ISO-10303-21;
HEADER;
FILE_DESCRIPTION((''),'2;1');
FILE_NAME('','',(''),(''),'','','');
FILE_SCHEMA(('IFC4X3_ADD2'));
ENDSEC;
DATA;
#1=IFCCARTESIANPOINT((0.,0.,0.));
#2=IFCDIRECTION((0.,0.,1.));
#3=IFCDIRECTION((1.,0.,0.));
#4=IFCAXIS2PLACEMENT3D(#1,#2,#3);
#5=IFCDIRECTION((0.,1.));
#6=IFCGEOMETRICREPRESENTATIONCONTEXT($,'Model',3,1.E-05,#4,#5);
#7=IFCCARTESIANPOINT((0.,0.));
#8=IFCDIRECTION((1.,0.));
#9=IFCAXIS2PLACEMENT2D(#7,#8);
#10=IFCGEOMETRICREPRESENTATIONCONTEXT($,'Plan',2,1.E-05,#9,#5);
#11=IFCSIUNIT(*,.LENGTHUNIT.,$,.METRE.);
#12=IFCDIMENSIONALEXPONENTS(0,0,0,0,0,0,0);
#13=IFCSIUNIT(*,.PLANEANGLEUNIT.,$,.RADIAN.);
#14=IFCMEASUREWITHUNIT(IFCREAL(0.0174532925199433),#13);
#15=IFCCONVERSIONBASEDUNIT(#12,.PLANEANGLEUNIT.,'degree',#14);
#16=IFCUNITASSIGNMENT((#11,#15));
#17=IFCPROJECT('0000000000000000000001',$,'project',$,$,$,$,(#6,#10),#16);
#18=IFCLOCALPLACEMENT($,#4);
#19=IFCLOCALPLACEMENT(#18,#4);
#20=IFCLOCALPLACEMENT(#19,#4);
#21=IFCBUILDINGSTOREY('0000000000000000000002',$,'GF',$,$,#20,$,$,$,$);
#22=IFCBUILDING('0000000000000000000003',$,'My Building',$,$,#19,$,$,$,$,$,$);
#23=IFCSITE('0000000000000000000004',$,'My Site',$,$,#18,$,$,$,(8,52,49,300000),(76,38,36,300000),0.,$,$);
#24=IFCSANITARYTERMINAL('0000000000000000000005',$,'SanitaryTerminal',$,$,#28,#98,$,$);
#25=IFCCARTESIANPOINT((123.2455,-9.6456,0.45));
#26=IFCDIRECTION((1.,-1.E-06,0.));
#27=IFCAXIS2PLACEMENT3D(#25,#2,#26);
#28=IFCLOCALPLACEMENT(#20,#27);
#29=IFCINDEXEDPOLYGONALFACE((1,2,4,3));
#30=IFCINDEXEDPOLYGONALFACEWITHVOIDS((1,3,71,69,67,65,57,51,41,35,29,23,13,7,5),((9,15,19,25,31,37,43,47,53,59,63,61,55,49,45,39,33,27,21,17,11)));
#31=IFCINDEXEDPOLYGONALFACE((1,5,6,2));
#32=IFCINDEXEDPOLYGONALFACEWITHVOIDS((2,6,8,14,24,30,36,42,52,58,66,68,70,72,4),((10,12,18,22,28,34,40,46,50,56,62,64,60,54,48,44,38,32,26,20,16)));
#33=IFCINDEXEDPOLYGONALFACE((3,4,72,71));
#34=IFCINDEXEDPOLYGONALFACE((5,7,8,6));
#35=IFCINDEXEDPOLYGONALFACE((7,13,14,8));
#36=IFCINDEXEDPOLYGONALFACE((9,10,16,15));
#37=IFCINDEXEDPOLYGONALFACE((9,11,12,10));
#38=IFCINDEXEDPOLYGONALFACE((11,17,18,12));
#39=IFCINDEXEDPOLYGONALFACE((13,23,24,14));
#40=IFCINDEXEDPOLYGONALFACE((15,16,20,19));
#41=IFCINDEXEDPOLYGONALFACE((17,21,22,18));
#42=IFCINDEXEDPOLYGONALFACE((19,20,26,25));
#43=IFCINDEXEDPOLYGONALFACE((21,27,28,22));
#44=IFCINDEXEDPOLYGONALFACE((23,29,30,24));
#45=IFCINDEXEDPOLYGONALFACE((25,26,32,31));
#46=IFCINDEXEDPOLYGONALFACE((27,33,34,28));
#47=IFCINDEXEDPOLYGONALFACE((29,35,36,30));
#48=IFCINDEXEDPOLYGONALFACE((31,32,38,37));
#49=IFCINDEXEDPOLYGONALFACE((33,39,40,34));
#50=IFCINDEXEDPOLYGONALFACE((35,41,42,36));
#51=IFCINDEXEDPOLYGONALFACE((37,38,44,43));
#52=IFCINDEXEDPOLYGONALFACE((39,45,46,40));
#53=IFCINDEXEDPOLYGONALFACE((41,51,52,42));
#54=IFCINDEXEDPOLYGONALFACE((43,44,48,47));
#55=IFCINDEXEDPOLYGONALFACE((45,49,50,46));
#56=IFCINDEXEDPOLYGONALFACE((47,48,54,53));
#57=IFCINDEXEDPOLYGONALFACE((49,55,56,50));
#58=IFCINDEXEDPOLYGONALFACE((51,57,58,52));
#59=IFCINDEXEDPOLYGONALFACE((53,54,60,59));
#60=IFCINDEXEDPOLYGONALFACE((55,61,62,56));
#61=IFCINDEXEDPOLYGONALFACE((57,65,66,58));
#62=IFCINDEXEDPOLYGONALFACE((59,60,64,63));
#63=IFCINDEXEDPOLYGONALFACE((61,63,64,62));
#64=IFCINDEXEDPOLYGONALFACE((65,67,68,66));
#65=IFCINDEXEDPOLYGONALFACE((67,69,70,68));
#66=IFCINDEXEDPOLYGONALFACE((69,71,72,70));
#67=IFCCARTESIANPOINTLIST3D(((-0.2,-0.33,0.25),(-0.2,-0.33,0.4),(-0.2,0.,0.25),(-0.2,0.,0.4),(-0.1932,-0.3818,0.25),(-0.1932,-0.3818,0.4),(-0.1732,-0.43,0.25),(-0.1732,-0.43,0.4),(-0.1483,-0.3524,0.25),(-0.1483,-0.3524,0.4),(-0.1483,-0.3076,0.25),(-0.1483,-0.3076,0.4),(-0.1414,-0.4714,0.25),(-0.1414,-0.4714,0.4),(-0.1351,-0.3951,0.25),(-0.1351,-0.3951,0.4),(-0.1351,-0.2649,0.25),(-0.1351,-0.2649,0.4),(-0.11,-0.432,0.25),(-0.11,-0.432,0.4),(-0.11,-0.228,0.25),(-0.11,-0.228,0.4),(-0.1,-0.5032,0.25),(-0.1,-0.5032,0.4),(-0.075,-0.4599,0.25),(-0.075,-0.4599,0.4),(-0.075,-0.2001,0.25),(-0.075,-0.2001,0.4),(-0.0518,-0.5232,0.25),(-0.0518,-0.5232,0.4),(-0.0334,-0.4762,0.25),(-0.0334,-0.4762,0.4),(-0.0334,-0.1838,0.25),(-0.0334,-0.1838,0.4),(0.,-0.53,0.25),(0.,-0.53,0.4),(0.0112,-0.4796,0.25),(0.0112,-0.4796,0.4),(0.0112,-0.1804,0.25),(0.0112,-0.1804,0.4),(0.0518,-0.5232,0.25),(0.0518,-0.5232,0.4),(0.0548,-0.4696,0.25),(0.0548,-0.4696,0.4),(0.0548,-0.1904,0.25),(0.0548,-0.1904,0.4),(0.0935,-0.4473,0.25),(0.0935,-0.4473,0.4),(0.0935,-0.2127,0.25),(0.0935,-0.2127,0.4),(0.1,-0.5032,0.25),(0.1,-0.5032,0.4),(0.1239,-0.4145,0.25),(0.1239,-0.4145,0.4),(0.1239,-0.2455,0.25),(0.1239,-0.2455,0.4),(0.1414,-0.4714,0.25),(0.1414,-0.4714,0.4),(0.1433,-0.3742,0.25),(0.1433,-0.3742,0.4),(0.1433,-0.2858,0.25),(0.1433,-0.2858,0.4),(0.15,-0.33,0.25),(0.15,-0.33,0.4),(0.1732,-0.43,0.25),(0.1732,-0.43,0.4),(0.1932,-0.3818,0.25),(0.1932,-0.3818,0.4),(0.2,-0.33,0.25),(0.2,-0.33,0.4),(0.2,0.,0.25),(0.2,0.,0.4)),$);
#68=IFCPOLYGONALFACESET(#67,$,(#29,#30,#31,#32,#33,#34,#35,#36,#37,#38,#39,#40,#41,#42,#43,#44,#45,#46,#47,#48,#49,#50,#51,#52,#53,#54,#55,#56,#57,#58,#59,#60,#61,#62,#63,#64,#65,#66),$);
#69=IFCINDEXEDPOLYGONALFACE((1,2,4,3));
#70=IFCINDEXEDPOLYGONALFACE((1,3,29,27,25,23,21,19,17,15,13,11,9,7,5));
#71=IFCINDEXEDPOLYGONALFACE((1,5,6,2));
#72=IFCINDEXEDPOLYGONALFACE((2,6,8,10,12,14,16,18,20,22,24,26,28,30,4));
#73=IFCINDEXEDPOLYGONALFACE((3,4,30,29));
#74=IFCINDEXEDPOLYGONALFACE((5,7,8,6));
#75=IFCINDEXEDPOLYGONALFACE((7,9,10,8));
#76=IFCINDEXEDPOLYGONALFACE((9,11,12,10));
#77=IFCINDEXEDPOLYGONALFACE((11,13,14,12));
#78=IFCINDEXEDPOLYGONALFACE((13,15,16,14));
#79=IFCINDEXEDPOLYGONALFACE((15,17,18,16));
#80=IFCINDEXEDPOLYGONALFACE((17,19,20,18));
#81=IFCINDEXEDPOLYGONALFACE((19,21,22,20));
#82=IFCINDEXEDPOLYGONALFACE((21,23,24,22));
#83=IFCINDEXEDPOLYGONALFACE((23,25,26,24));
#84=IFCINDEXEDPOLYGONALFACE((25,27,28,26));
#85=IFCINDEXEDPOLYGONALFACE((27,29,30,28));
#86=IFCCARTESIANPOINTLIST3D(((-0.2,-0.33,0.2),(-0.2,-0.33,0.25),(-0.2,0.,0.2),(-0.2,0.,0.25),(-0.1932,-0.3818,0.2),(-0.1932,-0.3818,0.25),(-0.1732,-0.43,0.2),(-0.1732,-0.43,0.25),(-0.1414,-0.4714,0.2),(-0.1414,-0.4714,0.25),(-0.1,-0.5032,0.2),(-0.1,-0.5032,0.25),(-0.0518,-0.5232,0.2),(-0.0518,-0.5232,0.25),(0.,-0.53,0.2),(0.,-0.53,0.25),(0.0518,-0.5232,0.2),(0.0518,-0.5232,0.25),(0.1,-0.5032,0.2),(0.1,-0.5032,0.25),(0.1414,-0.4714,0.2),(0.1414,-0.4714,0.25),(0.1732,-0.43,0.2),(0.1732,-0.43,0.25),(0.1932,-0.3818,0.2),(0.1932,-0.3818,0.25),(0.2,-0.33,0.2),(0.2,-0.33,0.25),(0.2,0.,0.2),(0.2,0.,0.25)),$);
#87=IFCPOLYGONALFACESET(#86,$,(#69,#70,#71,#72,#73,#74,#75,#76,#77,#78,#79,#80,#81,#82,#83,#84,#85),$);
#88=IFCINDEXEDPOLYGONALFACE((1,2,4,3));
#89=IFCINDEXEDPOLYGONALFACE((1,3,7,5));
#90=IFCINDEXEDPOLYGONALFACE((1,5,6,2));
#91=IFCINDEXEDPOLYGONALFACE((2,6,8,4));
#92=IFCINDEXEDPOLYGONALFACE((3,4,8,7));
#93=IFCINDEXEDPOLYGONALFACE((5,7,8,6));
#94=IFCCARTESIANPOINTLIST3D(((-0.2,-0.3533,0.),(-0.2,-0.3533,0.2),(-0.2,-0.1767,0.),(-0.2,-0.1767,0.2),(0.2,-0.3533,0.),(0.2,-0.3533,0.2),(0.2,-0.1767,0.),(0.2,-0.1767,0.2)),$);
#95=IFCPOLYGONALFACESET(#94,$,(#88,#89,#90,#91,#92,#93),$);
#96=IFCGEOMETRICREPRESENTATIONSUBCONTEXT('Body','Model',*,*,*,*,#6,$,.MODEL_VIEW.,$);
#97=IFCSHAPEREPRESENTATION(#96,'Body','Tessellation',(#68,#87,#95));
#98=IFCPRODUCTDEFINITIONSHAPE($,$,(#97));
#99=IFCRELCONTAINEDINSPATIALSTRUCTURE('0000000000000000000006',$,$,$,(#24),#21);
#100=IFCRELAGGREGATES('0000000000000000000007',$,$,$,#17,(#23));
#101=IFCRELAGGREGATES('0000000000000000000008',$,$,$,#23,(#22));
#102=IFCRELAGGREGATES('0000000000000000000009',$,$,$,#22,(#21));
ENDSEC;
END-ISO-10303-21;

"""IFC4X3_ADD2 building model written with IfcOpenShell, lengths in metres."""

from ifc_helpers import new_model, entity, si_unit, converted_unit, direction, frame, frame_2d, origin_with_axes, origin_2d_with_axis, place, context, subcontext, project, spatial, line, arc, indexed_curve, circle_curve, outline, extrude, shape, element, save


model = new_model("IFC4X3_ADD2")

# Units and contexts
model_context = context("Model", 3, precision=1e-05, world=origin_with_axes(), true_north=direction((0.0, 1.0)))
plan_context = context("Plan", 2, precision=1e-05, world=origin_2d_with_axis(), true_north=direction((0.0, 1.0)))
body_context_1 = subcontext(model_context, "Body", "Model", "MODEL_VIEW")
body_context_2 = subcontext(plan_context, "Body", "Plan", "PLAN_VIEW")
ifc_project = project(units=[si_unit("LENGTHUNIT", "METRE"), converted_unit("PLANEANGLEUNIT", "degree", entity("IfcReal", 0.0174532925199433), si_unit("PLANEANGLEUNIT", "RADIAN"), dimensions=[0, 0, 0, 0, 0, 0, 0])], contexts=[model_context, plan_context])

# Site, building, storey
site_placement = place(None, origin_with_axes())
site = spatial("IfcSite", under=ifc_project, at=site_placement, Name="My Site", RefLatitude=(8, 52, 49, 300000), RefLongitude=(76, 38, 36, 300000), RefElevation=0.0)
building_placement = place(site_placement, origin_with_axes())
building = spatial("IfcBuilding", under=site, at=building_placement, Name="My Building")
storey_placement = place(building_placement, origin_with_axes())
storey = spatial("IfcBuildingStorey", under=building, at=storey_placement, Name="GF")

# Sanitary terminal
sanitary_terminal_1_placement = place(storey_placement, frame((123.2455, -9.6456, 0.45), z_axis=(0.0, 0.0, 1.0), x_axis=(1.0, -0.000001, 0.0)))
element("IfcSanitaryTerminal", 1, at=sanitary_terminal_1_placement, inside=storey, Name="SanitaryTerminal", shapes=[
    shape(body_context_1, "Body", "SweptSolid", [extrude(outline(indexed_curve([(-0.2, 0.0), (0.2, 0.0), (0.2, -0.33), (0.1414, -0.4714), (0.0, -0.53), (-0.1414, -0.4714), (-0.2, -0.33)], segments=[line(1, 2), line(2, 3), arc(3, 4, 5), arc(5, 6, 7), line(7, 1)]), holes=[circle_curve(frame_2d((0.0, -0.33)), 0.15)]), frame((0.0, 0.0, 0.25), z_axis=(0.0, 0.0, 1.0), x_axis=(1.0, 0.0, 0.0)), (0.0, 0.0, 1.0), 0.15), extrude(outline(indexed_curve([(-0.2, 0.0), (0.2, 0.0), (0.2, -0.33), (0.1414, -0.4714), (0.0, -0.53), (-0.1414, -0.4714), (-0.2, -0.33)], segments=[line(1, 2), line(2, 3), arc(3, 4, 5), arc(5, 6, 7), line(7, 1)])), frame((0.0, 0.0, 0.2), z_axis=(0.0, 0.0, 1.0), x_axis=(1.0, 0.0, 0.0)), (0.0, 0.0, 1.0), 0.05), extrude(outline(indexed_curve([(-0.2, -0.1767), (0.2, -0.1767), (0.2, -0.3533), (-0.2, -0.3533)], segments=[line(1, 2, 3, 4, 1)])), origin_with_axes(), (0.0, 0.0, 1.0), 0.2)]),
    shape(body_context_2, "Body", "Annotation2D", [entity("IfcAnnotationFillArea", entity("IfcIndexedPolyCurve", entity("IfcCartesianPointList2D", [[-0.2, -0.159], [-0.1872, 0.0], [0.1872, 0.0], [0.2, -0.159], [0.1962, -0.2314], [0.1848, -0.301], [0.1764, -0.3339], [0.1663, -0.3651], [0.1546, -0.3944], [0.1414, -0.4213], [0.1269, -0.4458], [0.1111, -0.4675], [0.0943, -0.4862], [0.0765, -0.5018], [0.0581, -0.514], [0.039, -0.5229], [0.0196, -0.5282], [0.0, -0.53], [-0.0196, -0.5282], [-0.039, -0.5229], [-0.0581, -0.514], [-0.0765, -0.5018], [-0.0943, -0.4862], [-0.1111, -0.4675], [-0.1269, -0.4458], [-0.1414, -0.4213], [-0.1546, -0.3944], [-0.1663, -0.3651], [-0.1764, -0.3339], [-0.1848, -0.301], [-0.1962, -0.2314], [-0.1109, -0.1393], [-0.1068, -0.124], [-0.0957, -0.1129], [-0.0804, -0.1088], [0.0804, -0.1088], [-0.1025, -0.3926], [-0.1109, -0.3476], [-0.0424, -0.4563], [-0.0784, -0.4308], [0.0, -0.4652], [0.1068, -0.124], [0.1109, -0.1393], [0.0957, -0.1129], [0.0784, -0.4308], [0.0905, -0.4117], [0.0424, -0.4563], [0.1025, -0.3926], [0.1109, -0.3476]]), [entity("IfcLineIndex", [19, 18]), entity("IfcLineIndex", [18, 17]), entity("IfcLineIndex", [17, 16]), entity("IfcLineIndex", [16, 15]), entity("IfcLineIndex", [15, 14]), entity("IfcLineIndex", [14, 13]), entity("IfcLineIndex", [13, 12]), entity("IfcLineIndex", [12, 11]), entity("IfcLineIndex", [11, 46]), entity("IfcLineIndex", [46, 45]), entity("IfcLineIndex", [45, 47]), entity("IfcLineIndex", [47, 41]), entity("IfcLineIndex", [41, 39]), entity("IfcLineIndex", [39, 40]), entity("IfcLineIndex", [40, 37]), entity("IfcLineIndex", [37, 27]), entity("IfcLineIndex", [27, 26]), entity("IfcLineIndex", [26, 25]), entity("IfcLineIndex", [25, 24]), entity("IfcLineIndex", [24, 23]), entity("IfcLineIndex", [23, 22]), entity("IfcLineIndex", [22, 21]), entity("IfcLineIndex", [21, 20]), entity("IfcLineIndex", [20, 19])])), entity("IfcAnnotationFillArea", entity("IfcIndexedPolyCurve", entity("IfcCartesianPointList2D", [[-0.2, -0.159], [-0.1872, 0.0], [0.1872, 0.0], [0.2, -0.159], [0.1962, -0.2314], [0.1848, -0.301], [0.1764, -0.3339], [0.1663, -0.3651], [0.1546, -0.3944], [0.1414, -0.4213], [0.1269, -0.4458], [0.1111, -0.4675], [0.0943, -0.4862], [0.0765, -0.5018], [0.0581, -0.514], [0.039, -0.5229], [0.0196, -0.5282], [0.0, -0.53], [-0.0196, -0.5282], [-0.039, -0.5229], [-0.0581, -0.514], [-0.0765, -0.5018], [-0.0943, -0.4862], [-0.1111, -0.4675], [-0.1269, -0.4458], [-0.1414, -0.4213], [-0.1546, -0.3944], [-0.1663, -0.3651], [-0.1764, -0.3339], [-0.1848, -0.301], [-0.1962, -0.2314], [-0.1109, -0.1393], [-0.1068, -0.124], [-0.0957, -0.1129], [-0.0804, -0.1088], [0.0804, -0.1088], [-0.1025, -0.3926], [-0.1109, -0.3476], [-0.0424, -0.4563], [-0.0784, -0.4308], [0.0, -0.4652], [0.1068, -0.124], [0.1109, -0.1393], [0.0957, -0.1129], [0.0784, -0.4308], [0.0905, -0.4117], [0.0424, -0.4563], [0.1025, -0.3926], [0.1109, -0.3476]]), [entity("IfcLineIndex", [11, 10]), entity("IfcLineIndex", [10, 9]), entity("IfcLineIndex", [9, 8]), entity("IfcLineIndex", [8, 7]), entity("IfcLineIndex", [7, 6]), entity("IfcLineIndex", [6, 5]), entity("IfcLineIndex", [5, 4]), entity("IfcLineIndex", [4, 3]), entity("IfcLineIndex", [3, 2]), entity("IfcLineIndex", [2, 1]), entity("IfcLineIndex", [1, 31]), entity("IfcLineIndex", [31, 30]), entity("IfcLineIndex", [30, 29]), entity("IfcLineIndex", [29, 28]), entity("IfcLineIndex", [28, 27]), entity("IfcLineIndex", [27, 37]), entity("IfcLineIndex", [37, 38]), entity("IfcLineIndex", [38, 32]), entity("IfcLineIndex", [32, 33]), entity("IfcLineIndex", [33, 34]), entity("IfcLineIndex", [34, 35]), entity("IfcLineIndex", [35, 36]), entity("IfcLineIndex", [36, 44]), entity("IfcLineIndex", [44, 42]), entity("IfcLineIndex", [42, 43]), entity("IfcLineIndex", [43, 49]), entity("IfcLineIndex", [49, 48]), entity("IfcLineIndex", [48, 46]), entity("IfcLineIndex", [46, 11])])), entity("IfcAnnotationFillArea", entity("IfcIndexedPolyCurve", entity("IfcCartesianPointList2D", [[-0.2, -0.159], [-0.1872, 0.0], [0.1872, 0.0], [0.2, -0.159], [0.1962, -0.2314], [0.1848, -0.301], [0.1764, -0.3339], [0.1663, -0.3651], [0.1546, -0.3944], [0.1414, -0.4213], [0.1269, -0.4458], [0.1111, -0.4675], [0.0943, -0.4862], [0.0765, -0.5018], [0.0581, -0.514], [0.039, -0.5229], [0.0196, -0.5282], [0.0, -0.53], [-0.0196, -0.5282], [-0.039, -0.5229], [-0.0581, -0.514], [-0.0765, -0.5018], [-0.0943, -0.4862], [-0.1111, -0.4675], [-0.1269, -0.4458], [-0.1414, -0.4213], [-0.1546, -0.3944], [-0.1663, -0.3651], [-0.1764, -0.3339], [-0.1848, -0.301], [-0.1962, -0.2314], [-0.1109, -0.1393], [-0.1068, -0.124], [-0.0957, -0.1129], [-0.0804, -0.1088], [0.0804, -0.1088], [-0.1025, -0.3926], [-0.1109, -0.3476], [-0.0424, -0.4563], [-0.0784, -0.4308], [0.0, -0.4652], [0.1068, -0.124], [0.1109, -0.1393], [0.0957, -0.1129], [0.0784, -0.4308], [0.0905, -0.4117], [0.0424, -0.4563], [0.1025, -0.3926], [0.1109, -0.3476]]), [entity("IfcLineIndex", [45, 46]), entity("IfcLineIndex", [46, 48]), entity("IfcLineIndex", [48, 49]), entity("IfcLineIndex", [49, 43]), entity("IfcLineIndex", [43, 42]), entity("IfcLineIndex", [42, 44]), entity("IfcLineIndex", [44, 36]), entity("IfcLineIndex", [36, 35]), entity("IfcLineIndex", [35, 34]), entity("IfcLineIndex", [34, 33]), entity("IfcLineIndex", [33, 32]), entity("IfcLineIndex", [32, 38]), entity("IfcLineIndex", [38, 37]), entity("IfcLineIndex", [37, 40]), entity("IfcLineIndex", [40, 39]), entity("IfcLineIndex", [39, 41]), entity("IfcLineIndex", [41, 47]), entity("IfcLineIndex", [47, 45])]))]),
])

save(model, "model.ifc")
